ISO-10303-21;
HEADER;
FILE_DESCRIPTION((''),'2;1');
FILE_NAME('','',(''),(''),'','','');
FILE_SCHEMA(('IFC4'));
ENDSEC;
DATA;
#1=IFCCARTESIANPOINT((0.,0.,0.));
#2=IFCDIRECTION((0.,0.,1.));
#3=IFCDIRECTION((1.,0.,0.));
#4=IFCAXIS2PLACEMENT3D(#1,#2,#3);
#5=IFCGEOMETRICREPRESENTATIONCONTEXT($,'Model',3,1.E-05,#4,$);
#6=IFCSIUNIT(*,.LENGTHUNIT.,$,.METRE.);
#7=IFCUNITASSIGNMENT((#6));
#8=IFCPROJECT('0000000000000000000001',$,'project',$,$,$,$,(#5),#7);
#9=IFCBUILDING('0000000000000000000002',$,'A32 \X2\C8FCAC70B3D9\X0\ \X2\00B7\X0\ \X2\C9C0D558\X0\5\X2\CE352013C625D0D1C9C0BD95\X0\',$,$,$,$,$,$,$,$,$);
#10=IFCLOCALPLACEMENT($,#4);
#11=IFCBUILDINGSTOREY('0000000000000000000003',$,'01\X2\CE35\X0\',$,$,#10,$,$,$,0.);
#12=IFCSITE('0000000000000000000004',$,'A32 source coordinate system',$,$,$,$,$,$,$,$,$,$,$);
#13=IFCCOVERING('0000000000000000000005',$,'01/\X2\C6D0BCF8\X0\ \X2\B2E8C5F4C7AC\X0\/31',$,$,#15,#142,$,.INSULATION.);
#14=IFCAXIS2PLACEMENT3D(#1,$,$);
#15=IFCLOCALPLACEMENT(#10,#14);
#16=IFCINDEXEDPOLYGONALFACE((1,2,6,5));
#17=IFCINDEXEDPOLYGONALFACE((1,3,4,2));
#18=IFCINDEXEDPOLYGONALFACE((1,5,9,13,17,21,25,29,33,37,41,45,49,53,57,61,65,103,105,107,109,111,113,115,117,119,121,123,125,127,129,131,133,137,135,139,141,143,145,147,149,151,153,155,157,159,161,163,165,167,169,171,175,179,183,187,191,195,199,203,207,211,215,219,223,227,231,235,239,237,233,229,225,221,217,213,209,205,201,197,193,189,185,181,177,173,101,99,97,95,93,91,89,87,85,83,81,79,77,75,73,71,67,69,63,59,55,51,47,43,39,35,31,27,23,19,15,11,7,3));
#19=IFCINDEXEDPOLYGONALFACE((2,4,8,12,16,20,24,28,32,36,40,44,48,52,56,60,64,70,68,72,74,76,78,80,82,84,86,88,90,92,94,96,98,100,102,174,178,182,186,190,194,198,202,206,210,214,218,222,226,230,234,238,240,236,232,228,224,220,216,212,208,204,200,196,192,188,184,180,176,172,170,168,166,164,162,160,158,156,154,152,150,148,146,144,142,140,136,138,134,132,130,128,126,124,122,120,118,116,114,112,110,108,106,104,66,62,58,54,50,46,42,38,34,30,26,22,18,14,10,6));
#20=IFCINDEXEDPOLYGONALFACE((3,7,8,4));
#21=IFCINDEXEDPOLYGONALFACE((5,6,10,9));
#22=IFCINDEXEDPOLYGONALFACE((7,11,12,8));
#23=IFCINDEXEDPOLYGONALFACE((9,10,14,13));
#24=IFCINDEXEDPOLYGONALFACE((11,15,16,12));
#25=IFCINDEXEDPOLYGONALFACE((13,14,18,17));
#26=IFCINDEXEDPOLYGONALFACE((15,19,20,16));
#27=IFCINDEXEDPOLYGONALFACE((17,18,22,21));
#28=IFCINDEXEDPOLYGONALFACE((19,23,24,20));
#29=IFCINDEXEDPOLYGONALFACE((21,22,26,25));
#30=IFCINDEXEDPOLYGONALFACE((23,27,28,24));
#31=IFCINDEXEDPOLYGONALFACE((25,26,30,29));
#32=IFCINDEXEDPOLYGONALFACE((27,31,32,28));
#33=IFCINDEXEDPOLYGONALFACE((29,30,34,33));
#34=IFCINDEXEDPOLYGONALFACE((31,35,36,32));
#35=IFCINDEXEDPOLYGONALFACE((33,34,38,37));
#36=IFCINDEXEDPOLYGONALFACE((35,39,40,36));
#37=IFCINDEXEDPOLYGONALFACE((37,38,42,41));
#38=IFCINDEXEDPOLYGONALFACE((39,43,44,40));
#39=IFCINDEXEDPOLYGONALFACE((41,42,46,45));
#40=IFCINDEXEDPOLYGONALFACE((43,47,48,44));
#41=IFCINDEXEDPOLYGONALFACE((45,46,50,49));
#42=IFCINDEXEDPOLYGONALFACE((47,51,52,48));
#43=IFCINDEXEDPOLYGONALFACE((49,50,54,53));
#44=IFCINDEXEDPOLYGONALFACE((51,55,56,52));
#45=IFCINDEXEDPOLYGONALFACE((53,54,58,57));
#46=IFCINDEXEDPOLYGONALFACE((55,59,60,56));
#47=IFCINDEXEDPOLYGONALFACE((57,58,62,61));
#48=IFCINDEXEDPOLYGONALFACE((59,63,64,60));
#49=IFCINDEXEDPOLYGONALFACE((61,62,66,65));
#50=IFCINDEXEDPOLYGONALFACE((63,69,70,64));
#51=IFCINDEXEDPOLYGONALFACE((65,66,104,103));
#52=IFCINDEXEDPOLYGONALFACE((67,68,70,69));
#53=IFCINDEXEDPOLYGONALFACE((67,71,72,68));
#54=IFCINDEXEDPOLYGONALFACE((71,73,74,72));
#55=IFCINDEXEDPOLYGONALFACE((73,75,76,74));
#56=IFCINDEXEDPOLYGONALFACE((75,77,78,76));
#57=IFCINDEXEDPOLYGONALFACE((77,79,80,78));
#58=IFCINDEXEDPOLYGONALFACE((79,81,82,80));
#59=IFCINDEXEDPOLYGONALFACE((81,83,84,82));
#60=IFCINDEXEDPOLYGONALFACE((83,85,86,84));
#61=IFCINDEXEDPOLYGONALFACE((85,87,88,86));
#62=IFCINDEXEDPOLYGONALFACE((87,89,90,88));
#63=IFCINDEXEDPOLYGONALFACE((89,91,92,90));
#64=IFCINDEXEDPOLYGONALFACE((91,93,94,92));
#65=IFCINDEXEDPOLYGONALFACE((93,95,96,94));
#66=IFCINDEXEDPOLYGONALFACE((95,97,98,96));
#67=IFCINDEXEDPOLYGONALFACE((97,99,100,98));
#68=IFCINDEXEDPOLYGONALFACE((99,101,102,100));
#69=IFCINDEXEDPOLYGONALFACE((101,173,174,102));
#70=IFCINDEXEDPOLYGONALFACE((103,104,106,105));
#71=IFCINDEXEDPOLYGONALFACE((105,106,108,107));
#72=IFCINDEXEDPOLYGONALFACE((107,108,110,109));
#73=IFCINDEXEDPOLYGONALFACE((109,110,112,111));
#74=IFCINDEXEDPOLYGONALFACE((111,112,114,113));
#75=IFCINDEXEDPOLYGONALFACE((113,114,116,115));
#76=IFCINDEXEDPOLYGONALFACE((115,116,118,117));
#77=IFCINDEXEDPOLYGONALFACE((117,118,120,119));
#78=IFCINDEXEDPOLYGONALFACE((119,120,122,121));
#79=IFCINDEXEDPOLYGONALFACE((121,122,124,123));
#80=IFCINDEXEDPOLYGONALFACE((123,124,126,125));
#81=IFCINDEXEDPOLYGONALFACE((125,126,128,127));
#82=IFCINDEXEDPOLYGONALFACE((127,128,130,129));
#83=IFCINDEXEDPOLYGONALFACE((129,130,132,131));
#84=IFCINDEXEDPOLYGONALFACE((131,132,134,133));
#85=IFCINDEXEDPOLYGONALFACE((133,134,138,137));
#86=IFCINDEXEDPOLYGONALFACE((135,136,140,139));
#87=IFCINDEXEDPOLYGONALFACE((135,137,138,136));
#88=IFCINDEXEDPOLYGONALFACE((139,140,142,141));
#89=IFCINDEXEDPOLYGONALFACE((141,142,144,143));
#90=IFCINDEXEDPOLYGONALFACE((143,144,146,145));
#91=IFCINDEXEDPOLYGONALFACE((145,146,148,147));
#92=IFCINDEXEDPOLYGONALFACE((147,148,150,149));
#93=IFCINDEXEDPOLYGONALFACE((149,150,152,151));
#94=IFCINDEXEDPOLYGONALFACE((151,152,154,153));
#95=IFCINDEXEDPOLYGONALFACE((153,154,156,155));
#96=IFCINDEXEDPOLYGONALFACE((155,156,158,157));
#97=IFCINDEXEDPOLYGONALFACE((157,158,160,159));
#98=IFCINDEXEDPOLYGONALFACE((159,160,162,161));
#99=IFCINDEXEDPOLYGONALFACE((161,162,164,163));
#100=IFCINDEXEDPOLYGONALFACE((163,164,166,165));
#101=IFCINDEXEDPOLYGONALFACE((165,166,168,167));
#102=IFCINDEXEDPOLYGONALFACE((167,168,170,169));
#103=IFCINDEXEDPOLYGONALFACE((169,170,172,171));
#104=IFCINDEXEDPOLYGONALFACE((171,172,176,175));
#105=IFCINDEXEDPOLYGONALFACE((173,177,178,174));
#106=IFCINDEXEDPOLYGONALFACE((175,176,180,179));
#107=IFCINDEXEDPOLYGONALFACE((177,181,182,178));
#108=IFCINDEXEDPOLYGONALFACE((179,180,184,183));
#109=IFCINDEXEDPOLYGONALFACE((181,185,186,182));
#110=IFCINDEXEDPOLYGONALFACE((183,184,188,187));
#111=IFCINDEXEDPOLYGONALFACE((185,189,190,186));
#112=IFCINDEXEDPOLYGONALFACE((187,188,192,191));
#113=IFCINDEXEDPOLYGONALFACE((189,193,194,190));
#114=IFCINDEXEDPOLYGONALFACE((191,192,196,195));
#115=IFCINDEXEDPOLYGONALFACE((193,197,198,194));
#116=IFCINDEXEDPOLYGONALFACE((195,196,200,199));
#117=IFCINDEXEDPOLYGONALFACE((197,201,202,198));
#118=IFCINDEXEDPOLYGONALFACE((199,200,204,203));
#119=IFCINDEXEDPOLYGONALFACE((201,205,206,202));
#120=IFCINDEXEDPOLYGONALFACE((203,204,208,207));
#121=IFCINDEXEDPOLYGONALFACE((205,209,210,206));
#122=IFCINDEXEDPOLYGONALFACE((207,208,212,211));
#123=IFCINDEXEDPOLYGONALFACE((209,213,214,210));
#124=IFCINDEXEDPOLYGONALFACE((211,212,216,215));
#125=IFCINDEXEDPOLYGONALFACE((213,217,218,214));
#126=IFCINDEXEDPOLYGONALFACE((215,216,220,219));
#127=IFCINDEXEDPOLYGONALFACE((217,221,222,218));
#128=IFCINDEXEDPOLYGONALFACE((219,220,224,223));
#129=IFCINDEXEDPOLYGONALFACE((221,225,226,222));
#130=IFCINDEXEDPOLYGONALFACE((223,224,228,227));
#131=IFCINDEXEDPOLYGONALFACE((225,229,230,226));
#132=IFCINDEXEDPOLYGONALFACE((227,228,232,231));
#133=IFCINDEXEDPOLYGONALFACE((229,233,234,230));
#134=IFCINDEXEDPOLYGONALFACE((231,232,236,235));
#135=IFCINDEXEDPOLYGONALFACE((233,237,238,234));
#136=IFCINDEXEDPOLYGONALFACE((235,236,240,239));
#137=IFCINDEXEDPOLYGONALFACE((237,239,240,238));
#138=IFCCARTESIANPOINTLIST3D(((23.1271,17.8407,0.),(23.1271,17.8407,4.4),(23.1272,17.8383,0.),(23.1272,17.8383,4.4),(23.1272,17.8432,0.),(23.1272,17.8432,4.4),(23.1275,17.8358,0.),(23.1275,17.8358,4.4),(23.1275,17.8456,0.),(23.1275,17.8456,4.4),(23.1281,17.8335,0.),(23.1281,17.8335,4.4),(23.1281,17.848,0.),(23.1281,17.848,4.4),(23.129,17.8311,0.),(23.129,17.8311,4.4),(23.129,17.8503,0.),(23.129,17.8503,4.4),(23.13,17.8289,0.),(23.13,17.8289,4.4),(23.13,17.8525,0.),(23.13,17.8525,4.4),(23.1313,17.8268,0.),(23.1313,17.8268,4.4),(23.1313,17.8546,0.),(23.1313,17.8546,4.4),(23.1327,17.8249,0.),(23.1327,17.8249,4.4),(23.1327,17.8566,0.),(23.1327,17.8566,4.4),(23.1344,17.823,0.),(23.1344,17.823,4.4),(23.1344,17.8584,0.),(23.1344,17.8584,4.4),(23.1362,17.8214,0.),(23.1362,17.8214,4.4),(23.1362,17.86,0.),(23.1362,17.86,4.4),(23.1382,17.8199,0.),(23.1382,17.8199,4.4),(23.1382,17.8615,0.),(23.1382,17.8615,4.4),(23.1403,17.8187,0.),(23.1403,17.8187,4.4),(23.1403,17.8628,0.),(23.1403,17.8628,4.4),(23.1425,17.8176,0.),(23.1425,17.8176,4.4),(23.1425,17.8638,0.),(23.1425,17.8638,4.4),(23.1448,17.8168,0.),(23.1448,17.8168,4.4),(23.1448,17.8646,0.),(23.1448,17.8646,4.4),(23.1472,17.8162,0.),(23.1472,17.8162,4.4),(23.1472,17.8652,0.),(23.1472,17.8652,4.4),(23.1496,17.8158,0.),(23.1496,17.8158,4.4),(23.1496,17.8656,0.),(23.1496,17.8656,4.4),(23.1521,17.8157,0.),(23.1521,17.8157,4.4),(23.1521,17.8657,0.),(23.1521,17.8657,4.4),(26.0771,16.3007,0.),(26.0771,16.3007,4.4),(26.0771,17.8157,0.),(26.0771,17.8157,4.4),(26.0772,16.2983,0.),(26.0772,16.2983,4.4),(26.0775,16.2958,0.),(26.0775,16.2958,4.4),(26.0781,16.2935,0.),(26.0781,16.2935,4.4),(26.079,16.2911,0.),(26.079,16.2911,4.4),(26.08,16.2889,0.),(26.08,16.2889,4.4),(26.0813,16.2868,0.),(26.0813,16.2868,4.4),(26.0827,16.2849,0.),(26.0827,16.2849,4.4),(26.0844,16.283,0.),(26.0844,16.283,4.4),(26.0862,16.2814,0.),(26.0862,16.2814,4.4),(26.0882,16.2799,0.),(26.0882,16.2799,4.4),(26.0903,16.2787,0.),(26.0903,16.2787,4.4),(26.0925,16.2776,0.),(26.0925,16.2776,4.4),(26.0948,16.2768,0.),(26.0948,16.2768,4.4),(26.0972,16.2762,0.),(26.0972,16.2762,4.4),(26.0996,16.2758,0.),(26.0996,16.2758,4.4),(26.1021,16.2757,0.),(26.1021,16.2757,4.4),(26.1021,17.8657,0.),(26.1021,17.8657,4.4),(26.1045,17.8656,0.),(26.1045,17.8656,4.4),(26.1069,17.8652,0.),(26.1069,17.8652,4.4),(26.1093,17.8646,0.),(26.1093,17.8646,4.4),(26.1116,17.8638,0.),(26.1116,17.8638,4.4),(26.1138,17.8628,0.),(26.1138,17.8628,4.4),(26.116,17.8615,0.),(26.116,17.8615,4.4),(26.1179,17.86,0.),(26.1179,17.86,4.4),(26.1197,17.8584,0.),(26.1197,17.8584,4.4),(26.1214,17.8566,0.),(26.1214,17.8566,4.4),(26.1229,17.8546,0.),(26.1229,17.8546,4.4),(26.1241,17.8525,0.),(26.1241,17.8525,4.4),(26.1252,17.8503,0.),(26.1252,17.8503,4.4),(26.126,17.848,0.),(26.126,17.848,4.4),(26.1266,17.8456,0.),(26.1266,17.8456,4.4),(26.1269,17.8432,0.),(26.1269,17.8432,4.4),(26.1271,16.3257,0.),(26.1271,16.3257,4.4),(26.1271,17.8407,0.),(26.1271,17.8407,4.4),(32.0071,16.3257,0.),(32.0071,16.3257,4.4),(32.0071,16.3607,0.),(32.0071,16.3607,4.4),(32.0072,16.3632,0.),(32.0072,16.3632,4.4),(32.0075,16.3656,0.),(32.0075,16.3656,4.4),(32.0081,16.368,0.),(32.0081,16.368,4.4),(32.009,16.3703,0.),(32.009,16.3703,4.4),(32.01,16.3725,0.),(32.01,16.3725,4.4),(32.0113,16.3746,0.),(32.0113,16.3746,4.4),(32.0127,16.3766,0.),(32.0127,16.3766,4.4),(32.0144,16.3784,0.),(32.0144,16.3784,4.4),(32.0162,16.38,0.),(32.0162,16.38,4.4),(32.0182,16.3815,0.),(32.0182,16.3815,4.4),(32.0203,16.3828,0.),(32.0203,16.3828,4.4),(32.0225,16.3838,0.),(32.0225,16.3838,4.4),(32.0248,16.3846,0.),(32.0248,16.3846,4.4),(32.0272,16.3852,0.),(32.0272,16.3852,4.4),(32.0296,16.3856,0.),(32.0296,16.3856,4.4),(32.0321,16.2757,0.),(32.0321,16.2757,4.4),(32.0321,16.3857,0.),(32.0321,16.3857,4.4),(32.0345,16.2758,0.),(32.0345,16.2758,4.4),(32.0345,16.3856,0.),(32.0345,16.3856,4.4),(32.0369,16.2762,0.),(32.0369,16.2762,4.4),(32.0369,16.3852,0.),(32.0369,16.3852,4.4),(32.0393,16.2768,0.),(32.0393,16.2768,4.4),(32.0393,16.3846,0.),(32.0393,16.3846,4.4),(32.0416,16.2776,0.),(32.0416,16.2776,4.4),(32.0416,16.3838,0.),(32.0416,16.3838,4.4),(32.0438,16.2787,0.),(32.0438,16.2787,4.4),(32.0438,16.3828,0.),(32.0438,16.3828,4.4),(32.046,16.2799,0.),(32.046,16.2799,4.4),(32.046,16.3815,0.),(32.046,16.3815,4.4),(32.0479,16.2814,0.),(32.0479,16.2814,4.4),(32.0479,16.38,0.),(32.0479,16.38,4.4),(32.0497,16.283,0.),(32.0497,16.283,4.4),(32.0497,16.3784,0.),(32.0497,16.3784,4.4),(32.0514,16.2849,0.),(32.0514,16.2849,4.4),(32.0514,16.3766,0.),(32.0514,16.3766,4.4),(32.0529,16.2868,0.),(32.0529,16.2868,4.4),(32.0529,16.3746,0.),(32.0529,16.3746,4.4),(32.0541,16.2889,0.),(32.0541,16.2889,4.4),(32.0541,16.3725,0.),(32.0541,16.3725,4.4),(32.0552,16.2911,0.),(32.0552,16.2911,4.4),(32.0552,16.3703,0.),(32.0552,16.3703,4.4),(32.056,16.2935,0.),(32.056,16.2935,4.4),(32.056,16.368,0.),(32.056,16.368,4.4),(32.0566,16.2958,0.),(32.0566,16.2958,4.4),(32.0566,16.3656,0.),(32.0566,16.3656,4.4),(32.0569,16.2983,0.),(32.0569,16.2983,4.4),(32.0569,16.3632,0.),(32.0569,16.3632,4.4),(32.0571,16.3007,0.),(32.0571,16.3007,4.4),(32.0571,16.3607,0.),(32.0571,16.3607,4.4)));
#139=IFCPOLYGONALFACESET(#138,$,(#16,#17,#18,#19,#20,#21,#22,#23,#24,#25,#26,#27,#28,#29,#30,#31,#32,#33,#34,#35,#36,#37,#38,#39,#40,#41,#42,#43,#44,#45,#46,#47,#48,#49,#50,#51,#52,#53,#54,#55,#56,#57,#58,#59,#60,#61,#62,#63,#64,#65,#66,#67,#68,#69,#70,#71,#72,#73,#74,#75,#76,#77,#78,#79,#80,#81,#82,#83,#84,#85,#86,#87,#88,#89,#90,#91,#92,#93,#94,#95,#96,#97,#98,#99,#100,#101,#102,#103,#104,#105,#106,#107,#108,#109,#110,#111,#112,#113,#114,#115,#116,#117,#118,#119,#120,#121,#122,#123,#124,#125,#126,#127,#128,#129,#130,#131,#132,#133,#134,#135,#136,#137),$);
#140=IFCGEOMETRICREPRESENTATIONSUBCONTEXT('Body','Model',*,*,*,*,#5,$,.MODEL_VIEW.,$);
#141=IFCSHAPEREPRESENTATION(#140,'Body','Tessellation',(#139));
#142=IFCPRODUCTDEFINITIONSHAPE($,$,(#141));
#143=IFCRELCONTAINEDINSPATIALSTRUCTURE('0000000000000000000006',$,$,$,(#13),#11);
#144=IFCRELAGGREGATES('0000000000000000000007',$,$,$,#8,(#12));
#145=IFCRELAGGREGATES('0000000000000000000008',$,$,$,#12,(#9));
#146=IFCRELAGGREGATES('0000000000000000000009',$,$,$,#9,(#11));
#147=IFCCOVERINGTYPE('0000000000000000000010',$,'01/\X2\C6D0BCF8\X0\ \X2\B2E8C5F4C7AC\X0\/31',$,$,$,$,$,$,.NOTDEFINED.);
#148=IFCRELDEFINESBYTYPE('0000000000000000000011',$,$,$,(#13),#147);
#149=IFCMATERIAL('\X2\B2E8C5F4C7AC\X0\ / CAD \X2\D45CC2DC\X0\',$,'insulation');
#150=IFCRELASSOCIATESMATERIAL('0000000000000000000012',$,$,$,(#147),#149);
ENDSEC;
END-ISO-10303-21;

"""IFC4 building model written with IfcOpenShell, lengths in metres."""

from ifc_helpers import new_model, si_unit, origin, origin_with_axes, place, context, subcontext, project, spatial, polyline, outline, extrude, source, transform, mapped, material, type_object, type_shapes, element, save


model = new_model("IFC4")

# Units and contexts
model_context = context("Model", 3, precision=1e-05, world=origin_with_axes())
body_context = subcontext(model_context, "Body", "Model", "MODEL_VIEW")
ifc_project = project(units=[si_unit("LENGTHUNIT", "METRE")], contexts=[model_context])

# Site, building, storey
site = spatial("IfcSite", under=ifc_project, Name="A32 source coordinate system")
building = spatial("IfcBuilding", under=site, Name="A32 주거동 · 지하5층–옥탑지붕")
storey_placement = place(None, origin_with_axes())
storey = spatial("IfcBuildingStorey", under=building, at=storey_placement, Name="01층", Elevation=0.0)

# Covering
ifc_material = material(Name="단열재 / CAD 표시", Category="insulation")
covering_type_1 = type_object("IfcCoveringType", Name="01/원본 단열재/31", PredefinedType="NOTDEFINED", material=ifc_material)
shared_shape_1 = source(origin(), body_context, "Body", "SweptSolid", [
    extrude(outline(polyline([(23.1403, 17.8187), (23.1382, 17.8199), (23.1362, 17.8214), (23.1344, 17.823), (23.1327, 17.8249), (23.1313, 17.8268), (23.13, 17.8289), (23.129, 17.8311), (23.1281, 17.8335), (23.1275, 17.8358), (23.1272, 17.8383), (23.1271, 17.8407), (23.1272, 17.8432), (23.1275, 17.8456), (23.1281, 17.848), (23.129, 17.8503), (23.13, 17.8525), (23.1313, 17.8546), (23.1327, 17.8566), (23.1344, 17.8584), (23.1362, 17.86), (23.1382, 17.8615), (23.1403, 17.8628), (23.1425, 17.8638), (23.1448, 17.8646), (23.1472, 17.8652), (23.1496, 17.8656), (23.1521, 17.8657), (26.1021, 17.8657), (26.1045, 17.8656), (26.1069, 17.8652), (26.1093, 17.8646), (26.1116, 17.8638), (26.1138, 17.8628), (26.116, 17.8615), (26.1179, 17.86), (26.1197, 17.8584), (26.1214, 17.8566), (26.1229, 17.8546), (26.1241, 17.8525), (26.1252, 17.8503), (26.126, 17.848), (26.1266, 17.8456), (26.1269, 17.8432), (26.1271, 17.8407), (26.1271, 16.3257), (32.0071, 16.3257), (32.0071, 16.3607), (32.0072, 16.3632), (32.0075, 16.3656), (32.0081, 16.368), (32.009, 16.3703), (32.01, 16.3725), (32.0113, 16.3746), (32.0127, 16.3766), (32.0144, 16.3784), (32.0162, 16.38), (32.0182, 16.3815), (32.0203, 16.3828), (32.0225, 16.3838), (32.0248, 16.3846), (32.0272, 16.3852), (32.0296, 16.3856), (32.0321, 16.3857), (32.0345, 16.3856), (32.0369, 16.3852), (32.0393, 16.3846), (32.0416, 16.3838), (32.0438, 16.3828), (32.046, 16.3815), (32.0479, 16.38), (32.0497, 16.3784), (32.0514, 16.3766), (32.0529, 16.3746), (32.0541, 16.3725), (32.0552, 16.3703), (32.056, 16.368), (32.0566, 16.3656), (32.0569, 16.3632), (32.0571, 16.3607), (32.0571, 16.3007), (32.0569, 16.2983), (32.0566, 16.2958), (32.056, 16.2935), (32.0552, 16.2911), (32.0541, 16.2889), (32.0529, 16.2868), (32.0514, 16.2849), (32.0497, 16.283), (32.0479, 16.2814), (32.046, 16.2799), (32.0438, 16.2787), (32.0416, 16.2776), (32.0393, 16.2768), (32.0369, 16.2762), (32.0345, 16.2758), (32.0321, 16.2757), (26.1021, 16.2757), (26.0996, 16.2758), (26.0972, 16.2762), (26.0948, 16.2768), (26.0925, 16.2776), (26.0903, 16.2787), (26.0882, 16.2799), (26.0862, 16.2814), (26.0844, 16.283), (26.0827, 16.2849), (26.0813, 16.2868), (26.08, 16.2889), (26.079, 16.2911), (26.0781, 16.2935), (26.0775, 16.2958), (26.0772, 16.2983), (26.0771, 16.3007), (26.0771, 17.8157), (23.1521, 17.8157), (23.1496, 17.8158), (23.1472, 17.8162), (23.1448, 17.8168), (23.1425, 17.8176), (23.1403, 17.8187)])), origin(), (0.0, 0.0, 1.0), 4.4),
])
type_shapes(covering_type_1, [shared_shape_1])
covering_1_placement = place(storey_placement, origin_with_axes())
element("IfcCovering", 1, at=covering_1_placement, inside=storey, type_object=covering_type_1, Name="01/원본 단열재/31", PredefinedType="INSULATION", context=body_context, shape_type="MappedRepresentation", body=[
    mapped(shared_shape_1, transform((0.0, 0.0, 0.0), scale=1.0)),
])

save(model, "model.ifc")
